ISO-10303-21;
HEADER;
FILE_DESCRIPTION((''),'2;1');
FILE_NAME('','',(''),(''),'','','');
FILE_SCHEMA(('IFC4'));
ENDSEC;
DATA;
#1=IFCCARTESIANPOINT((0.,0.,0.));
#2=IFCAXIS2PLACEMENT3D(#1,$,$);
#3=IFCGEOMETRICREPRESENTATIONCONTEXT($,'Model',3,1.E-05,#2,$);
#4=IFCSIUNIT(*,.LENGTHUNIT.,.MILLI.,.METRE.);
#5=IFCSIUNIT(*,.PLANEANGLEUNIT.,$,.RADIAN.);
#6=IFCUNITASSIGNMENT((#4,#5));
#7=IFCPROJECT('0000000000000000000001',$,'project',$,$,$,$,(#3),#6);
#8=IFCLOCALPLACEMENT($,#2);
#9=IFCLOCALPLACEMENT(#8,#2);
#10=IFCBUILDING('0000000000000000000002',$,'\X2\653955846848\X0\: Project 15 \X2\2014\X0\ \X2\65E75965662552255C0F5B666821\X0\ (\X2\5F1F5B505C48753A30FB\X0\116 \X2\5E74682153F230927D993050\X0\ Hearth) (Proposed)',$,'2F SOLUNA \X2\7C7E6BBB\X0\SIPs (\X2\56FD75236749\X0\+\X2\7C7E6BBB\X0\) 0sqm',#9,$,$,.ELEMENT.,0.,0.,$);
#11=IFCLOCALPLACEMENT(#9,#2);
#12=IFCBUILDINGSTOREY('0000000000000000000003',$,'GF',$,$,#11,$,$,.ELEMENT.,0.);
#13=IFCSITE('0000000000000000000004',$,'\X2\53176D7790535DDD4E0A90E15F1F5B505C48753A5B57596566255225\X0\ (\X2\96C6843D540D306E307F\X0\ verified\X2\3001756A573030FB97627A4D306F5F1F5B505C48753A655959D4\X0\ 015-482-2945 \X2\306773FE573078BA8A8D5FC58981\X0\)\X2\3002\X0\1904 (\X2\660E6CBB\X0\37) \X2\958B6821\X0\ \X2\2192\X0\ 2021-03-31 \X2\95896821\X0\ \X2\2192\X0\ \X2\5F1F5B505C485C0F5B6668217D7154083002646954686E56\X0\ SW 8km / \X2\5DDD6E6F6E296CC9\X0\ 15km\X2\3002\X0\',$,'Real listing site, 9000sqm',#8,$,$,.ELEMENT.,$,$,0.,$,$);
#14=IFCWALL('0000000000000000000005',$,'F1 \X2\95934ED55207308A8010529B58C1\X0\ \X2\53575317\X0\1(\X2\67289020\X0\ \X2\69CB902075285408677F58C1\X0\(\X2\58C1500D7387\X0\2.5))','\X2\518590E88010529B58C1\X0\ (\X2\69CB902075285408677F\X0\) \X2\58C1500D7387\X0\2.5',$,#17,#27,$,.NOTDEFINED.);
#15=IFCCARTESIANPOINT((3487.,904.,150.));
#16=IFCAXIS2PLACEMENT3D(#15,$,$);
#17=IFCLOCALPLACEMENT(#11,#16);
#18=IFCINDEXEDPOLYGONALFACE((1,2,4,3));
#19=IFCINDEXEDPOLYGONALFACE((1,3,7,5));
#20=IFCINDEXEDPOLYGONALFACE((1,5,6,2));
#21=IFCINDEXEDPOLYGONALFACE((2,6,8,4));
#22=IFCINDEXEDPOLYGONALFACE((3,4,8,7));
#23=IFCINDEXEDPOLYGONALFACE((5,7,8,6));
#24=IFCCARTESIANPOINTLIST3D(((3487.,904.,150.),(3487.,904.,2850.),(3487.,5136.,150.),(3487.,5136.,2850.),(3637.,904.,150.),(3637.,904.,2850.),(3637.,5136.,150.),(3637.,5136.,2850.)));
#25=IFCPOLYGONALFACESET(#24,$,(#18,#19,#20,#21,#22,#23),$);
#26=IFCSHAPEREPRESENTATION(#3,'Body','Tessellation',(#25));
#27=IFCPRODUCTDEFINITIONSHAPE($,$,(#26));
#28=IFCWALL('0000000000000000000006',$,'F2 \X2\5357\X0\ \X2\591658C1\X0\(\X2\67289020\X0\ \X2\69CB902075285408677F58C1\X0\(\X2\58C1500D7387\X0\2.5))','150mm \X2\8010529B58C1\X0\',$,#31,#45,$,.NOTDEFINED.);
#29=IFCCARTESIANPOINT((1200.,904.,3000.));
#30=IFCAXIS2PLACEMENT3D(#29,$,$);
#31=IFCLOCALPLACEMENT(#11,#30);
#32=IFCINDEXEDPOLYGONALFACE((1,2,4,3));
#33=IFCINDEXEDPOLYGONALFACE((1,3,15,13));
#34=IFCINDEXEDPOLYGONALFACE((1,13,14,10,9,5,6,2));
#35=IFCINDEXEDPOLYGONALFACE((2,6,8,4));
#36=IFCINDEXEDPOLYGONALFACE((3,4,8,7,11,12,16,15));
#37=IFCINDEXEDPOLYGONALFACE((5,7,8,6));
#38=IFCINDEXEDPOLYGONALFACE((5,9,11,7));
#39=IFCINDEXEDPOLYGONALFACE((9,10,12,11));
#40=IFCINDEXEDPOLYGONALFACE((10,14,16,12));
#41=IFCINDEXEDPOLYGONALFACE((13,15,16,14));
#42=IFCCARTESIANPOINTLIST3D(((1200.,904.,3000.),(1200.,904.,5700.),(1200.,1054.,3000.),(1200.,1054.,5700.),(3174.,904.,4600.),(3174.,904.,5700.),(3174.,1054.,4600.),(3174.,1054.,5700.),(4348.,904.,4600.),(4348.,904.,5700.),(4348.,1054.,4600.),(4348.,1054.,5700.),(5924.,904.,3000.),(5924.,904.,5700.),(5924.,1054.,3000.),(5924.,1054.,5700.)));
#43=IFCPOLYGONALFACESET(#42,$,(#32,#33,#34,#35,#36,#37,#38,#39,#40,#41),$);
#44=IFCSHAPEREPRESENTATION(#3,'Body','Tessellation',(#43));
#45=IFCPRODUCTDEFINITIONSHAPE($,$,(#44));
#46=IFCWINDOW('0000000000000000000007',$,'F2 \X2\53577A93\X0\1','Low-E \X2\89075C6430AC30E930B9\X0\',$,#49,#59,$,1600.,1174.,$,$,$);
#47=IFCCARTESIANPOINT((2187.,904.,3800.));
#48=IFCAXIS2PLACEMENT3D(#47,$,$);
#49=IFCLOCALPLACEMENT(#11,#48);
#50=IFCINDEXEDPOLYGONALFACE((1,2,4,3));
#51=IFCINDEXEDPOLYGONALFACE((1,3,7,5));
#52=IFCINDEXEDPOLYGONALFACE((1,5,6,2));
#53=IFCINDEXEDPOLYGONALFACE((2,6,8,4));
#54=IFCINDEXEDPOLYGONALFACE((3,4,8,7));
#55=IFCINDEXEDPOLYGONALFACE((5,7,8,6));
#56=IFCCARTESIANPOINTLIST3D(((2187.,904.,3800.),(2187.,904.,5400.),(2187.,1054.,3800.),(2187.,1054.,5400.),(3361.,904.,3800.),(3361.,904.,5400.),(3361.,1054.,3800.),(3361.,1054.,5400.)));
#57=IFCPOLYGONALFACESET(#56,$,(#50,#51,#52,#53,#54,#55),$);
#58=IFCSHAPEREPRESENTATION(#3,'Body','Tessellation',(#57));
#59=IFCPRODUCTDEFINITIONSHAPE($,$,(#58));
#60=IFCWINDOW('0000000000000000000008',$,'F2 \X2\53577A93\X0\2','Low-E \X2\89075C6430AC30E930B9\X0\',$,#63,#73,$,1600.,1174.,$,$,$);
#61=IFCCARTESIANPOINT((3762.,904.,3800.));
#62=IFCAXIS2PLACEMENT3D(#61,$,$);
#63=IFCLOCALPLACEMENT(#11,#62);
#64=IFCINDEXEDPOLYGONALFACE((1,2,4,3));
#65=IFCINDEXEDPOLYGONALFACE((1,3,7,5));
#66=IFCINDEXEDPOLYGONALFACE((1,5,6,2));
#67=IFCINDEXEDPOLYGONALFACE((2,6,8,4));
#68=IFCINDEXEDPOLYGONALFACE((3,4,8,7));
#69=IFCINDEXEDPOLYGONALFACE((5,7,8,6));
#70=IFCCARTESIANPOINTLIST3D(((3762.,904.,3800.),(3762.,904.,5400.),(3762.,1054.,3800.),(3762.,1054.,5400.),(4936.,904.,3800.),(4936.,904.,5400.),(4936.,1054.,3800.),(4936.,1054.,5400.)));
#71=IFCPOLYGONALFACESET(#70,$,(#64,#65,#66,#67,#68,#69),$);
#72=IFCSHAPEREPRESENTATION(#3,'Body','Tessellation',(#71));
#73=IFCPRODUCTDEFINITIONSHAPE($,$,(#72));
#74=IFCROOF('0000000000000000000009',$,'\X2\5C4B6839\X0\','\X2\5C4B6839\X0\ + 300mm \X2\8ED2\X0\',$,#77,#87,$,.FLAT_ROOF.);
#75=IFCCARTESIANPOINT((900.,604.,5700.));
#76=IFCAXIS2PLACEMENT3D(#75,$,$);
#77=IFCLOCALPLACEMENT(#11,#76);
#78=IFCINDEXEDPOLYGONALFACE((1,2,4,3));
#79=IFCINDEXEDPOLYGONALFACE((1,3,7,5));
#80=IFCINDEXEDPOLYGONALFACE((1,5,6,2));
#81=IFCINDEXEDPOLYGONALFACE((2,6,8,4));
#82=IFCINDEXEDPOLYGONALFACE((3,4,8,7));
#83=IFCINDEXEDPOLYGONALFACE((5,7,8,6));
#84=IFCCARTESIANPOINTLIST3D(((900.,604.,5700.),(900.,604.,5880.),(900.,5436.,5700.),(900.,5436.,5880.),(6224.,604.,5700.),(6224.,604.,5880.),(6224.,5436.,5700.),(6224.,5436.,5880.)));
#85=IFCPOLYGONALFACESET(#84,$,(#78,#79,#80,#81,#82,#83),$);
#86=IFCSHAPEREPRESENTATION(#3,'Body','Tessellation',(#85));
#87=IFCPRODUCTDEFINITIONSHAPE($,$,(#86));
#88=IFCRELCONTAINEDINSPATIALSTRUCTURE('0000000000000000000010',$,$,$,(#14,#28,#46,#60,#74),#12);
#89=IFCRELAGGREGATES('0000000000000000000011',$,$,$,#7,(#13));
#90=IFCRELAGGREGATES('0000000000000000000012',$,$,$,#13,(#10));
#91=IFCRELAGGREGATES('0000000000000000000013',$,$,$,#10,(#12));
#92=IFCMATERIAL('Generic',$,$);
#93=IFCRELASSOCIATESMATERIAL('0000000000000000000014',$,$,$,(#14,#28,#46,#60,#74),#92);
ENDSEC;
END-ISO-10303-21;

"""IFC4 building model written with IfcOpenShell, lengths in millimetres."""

from ifc_helpers import new_model, si_unit, frame, frame_2d, origin, place, context, project, spatial, rectangle, extrude, material, element, fill, save


model = new_model("IFC4")

# Units and contexts
model_context = context("Model", 3, precision=1e-05, world=origin())
ifc_project = project(units=[si_unit("LENGTHUNIT", "METRE", prefix="MILLI"), si_unit("PLANEANGLEUNIT", "RADIAN")], contexts=[model_context])

# Site, building, storey
site_placement = place(None, origin())
site = spatial("IfcSite", under=ifc_project, at=site_placement, Name="北海道川上郡弟子屈町字奥春別 (集落名のみ verified、番地・面積は弟子屈町教委 015-482-2945 で現地確認必要)。1904 (明治37) 開校 → 2021-03-31 閉校 → 弟子屈小学校統合。摩周湖 SW 8km / 川湯温泉 15km。", ObjectType="Real listing site, 9000sqm", CompositionType="ELEMENT", RefElevation=0.0)
building_placement = place(site_placement, origin())
building = spatial("IfcBuilding", under=site, at=building_placement, Name="改善案: Project 15 — 旧奥春別小学校 (弟子屈町・116 年校史を継ぐ Hearth) (Proposed)", ObjectType="2F SOLUNA 籾殻SIPs (国産杉+籾殻) 0sqm", CompositionType="ELEMENT", ElevationOfRefHeight=0.0, ElevationOfTerrain=0.0)
storey_placement = place(building_placement, origin())
storey = spatial("IfcBuildingStorey", under=building, at=storey_placement, Name="GF", CompositionType="ELEMENT", Elevation=0.0)

# Shared definitions
ifc_material_1 = material(Name="Generic")

# Wall
wall_1_placement = place(storey_placement, frame((3487.0, 904.0, 150.0)))
element("IfcWall", 1, at=wall_1_placement, inside=storey, material=ifc_material_1, Name="F1 間仕切り耐力壁 南北1(木造 構造用合板壁(壁倍率2.5))", Description="内部耐力壁 (構造用合板) 壁倍率2.5", PredefinedType="NOTDEFINED", context=model_context, shape_type="SweptSolid", body=[
    extrude(rectangle(XDim=150.0, YDim=4232.0, at=frame_2d((75.0, 2116.0))), frame((3487.0, 904.0, 150.0)), (0.0, 0.0, 1.0), 2700.0),
])

# Wall, openings, windows
wall_2_placement = place(storey_placement, frame((1200.0, 904.0, 3000.0)))
wall_2 = element("IfcWall", 2, at=wall_2_placement, inside=storey, material=ifc_material_1, Name="F2 南 外壁(木造 構造用合板壁(壁倍率2.5))", Description="150mm 耐力壁", PredefinedType="NOTDEFINED", context=model_context, shape_type="SweptSolid", body=[
    extrude(rectangle(XDim=4724.0, YDim=150.0, at=frame_2d((2362.0, 75.0))), frame((1200.0, 904.0, 3000.0)), (0.0, 0.0, 1.0), 2700.0),
])
opening_1_placement = place(storey_placement, frame((2187.0, 904.0, 3800.0)))
opening_1 = element("IfcOpeningElement", 3, at=opening_1_placement, cuts=wall_2, PredefinedType="NOTDEFINED", context=model_context, shape_type="SweptSolid", body=[
    extrude(rectangle(XDim=1174.0, YDim=150.0, at=frame_2d((587.0, 75.0))), frame((2187.0, 904.0, 3800.0)), (0.0, 0.0, 1.0), 1600.0),
])
opening_2_placement = place(storey_placement, frame((3762.0, 904.0, 3800.0)))
opening_2 = element("IfcOpeningElement", 4, at=opening_2_placement, cuts=wall_2, PredefinedType="NOTDEFINED", context=model_context, shape_type="SweptSolid", body=[
    extrude(rectangle(XDim=1174.0, YDim=150.0, at=frame_2d((587.0, 75.0))), frame((3762.0, 904.0, 3800.0)), (0.0, 0.0, 1.0), 1600.0),
])
window_1_placement = place(storey_placement, frame((2187.0, 904.0, 3800.0)))
window_1 = element("IfcWindow", 5, at=window_1_placement, inside=storey, material=ifc_material_1, Name="F2 南窓1", Description="Low-E 複層ガラス", OverallHeight=1600.0, OverallWidth=1174.0, context=model_context, shape_type="SweptSolid", body=[
    extrude(rectangle(XDim=1174.0, YDim=150.0, at=frame_2d((587.0, 75.0))), frame((2187.0, 904.0, 3800.0)), (0.0, 0.0, 1.0), 1600.0),
])
fill(opening_1, window_1)
window_2_placement = place(storey_placement, frame((3762.0, 904.0, 3800.0)))
window_2 = element("IfcWindow", 6, at=window_2_placement, inside=storey, material=ifc_material_1, Name="F2 南窓2", Description="Low-E 複層ガラス", OverallHeight=1600.0, OverallWidth=1174.0, context=model_context, shape_type="SweptSolid", body=[
    extrude(rectangle(XDim=1174.0, YDim=150.0, at=frame_2d((587.0, 75.0))), frame((3762.0, 904.0, 3800.0)), (0.0, 0.0, 1.0), 1600.0),
])
fill(opening_2, window_2)

# Roof
roof_placement = place(storey_placement, frame((900.0, 604.0, 5700.0)))
element("IfcRoof", 7, at=roof_placement, inside=storey, material=ifc_material_1, Name="屋根", Description="屋根 + 300mm 軒", PredefinedType="FLAT_ROOF", context=model_context, shape_type="SweptSolid", body=[
    extrude(rectangle(XDim=5324.0, YDim=4832.0, at=frame_2d((2662.0, 2416.0))), frame((900.0, 604.0, 5700.0)), (0.0, 0.0, 1.0), 180.0),
])

save(model, "model.ifc")
